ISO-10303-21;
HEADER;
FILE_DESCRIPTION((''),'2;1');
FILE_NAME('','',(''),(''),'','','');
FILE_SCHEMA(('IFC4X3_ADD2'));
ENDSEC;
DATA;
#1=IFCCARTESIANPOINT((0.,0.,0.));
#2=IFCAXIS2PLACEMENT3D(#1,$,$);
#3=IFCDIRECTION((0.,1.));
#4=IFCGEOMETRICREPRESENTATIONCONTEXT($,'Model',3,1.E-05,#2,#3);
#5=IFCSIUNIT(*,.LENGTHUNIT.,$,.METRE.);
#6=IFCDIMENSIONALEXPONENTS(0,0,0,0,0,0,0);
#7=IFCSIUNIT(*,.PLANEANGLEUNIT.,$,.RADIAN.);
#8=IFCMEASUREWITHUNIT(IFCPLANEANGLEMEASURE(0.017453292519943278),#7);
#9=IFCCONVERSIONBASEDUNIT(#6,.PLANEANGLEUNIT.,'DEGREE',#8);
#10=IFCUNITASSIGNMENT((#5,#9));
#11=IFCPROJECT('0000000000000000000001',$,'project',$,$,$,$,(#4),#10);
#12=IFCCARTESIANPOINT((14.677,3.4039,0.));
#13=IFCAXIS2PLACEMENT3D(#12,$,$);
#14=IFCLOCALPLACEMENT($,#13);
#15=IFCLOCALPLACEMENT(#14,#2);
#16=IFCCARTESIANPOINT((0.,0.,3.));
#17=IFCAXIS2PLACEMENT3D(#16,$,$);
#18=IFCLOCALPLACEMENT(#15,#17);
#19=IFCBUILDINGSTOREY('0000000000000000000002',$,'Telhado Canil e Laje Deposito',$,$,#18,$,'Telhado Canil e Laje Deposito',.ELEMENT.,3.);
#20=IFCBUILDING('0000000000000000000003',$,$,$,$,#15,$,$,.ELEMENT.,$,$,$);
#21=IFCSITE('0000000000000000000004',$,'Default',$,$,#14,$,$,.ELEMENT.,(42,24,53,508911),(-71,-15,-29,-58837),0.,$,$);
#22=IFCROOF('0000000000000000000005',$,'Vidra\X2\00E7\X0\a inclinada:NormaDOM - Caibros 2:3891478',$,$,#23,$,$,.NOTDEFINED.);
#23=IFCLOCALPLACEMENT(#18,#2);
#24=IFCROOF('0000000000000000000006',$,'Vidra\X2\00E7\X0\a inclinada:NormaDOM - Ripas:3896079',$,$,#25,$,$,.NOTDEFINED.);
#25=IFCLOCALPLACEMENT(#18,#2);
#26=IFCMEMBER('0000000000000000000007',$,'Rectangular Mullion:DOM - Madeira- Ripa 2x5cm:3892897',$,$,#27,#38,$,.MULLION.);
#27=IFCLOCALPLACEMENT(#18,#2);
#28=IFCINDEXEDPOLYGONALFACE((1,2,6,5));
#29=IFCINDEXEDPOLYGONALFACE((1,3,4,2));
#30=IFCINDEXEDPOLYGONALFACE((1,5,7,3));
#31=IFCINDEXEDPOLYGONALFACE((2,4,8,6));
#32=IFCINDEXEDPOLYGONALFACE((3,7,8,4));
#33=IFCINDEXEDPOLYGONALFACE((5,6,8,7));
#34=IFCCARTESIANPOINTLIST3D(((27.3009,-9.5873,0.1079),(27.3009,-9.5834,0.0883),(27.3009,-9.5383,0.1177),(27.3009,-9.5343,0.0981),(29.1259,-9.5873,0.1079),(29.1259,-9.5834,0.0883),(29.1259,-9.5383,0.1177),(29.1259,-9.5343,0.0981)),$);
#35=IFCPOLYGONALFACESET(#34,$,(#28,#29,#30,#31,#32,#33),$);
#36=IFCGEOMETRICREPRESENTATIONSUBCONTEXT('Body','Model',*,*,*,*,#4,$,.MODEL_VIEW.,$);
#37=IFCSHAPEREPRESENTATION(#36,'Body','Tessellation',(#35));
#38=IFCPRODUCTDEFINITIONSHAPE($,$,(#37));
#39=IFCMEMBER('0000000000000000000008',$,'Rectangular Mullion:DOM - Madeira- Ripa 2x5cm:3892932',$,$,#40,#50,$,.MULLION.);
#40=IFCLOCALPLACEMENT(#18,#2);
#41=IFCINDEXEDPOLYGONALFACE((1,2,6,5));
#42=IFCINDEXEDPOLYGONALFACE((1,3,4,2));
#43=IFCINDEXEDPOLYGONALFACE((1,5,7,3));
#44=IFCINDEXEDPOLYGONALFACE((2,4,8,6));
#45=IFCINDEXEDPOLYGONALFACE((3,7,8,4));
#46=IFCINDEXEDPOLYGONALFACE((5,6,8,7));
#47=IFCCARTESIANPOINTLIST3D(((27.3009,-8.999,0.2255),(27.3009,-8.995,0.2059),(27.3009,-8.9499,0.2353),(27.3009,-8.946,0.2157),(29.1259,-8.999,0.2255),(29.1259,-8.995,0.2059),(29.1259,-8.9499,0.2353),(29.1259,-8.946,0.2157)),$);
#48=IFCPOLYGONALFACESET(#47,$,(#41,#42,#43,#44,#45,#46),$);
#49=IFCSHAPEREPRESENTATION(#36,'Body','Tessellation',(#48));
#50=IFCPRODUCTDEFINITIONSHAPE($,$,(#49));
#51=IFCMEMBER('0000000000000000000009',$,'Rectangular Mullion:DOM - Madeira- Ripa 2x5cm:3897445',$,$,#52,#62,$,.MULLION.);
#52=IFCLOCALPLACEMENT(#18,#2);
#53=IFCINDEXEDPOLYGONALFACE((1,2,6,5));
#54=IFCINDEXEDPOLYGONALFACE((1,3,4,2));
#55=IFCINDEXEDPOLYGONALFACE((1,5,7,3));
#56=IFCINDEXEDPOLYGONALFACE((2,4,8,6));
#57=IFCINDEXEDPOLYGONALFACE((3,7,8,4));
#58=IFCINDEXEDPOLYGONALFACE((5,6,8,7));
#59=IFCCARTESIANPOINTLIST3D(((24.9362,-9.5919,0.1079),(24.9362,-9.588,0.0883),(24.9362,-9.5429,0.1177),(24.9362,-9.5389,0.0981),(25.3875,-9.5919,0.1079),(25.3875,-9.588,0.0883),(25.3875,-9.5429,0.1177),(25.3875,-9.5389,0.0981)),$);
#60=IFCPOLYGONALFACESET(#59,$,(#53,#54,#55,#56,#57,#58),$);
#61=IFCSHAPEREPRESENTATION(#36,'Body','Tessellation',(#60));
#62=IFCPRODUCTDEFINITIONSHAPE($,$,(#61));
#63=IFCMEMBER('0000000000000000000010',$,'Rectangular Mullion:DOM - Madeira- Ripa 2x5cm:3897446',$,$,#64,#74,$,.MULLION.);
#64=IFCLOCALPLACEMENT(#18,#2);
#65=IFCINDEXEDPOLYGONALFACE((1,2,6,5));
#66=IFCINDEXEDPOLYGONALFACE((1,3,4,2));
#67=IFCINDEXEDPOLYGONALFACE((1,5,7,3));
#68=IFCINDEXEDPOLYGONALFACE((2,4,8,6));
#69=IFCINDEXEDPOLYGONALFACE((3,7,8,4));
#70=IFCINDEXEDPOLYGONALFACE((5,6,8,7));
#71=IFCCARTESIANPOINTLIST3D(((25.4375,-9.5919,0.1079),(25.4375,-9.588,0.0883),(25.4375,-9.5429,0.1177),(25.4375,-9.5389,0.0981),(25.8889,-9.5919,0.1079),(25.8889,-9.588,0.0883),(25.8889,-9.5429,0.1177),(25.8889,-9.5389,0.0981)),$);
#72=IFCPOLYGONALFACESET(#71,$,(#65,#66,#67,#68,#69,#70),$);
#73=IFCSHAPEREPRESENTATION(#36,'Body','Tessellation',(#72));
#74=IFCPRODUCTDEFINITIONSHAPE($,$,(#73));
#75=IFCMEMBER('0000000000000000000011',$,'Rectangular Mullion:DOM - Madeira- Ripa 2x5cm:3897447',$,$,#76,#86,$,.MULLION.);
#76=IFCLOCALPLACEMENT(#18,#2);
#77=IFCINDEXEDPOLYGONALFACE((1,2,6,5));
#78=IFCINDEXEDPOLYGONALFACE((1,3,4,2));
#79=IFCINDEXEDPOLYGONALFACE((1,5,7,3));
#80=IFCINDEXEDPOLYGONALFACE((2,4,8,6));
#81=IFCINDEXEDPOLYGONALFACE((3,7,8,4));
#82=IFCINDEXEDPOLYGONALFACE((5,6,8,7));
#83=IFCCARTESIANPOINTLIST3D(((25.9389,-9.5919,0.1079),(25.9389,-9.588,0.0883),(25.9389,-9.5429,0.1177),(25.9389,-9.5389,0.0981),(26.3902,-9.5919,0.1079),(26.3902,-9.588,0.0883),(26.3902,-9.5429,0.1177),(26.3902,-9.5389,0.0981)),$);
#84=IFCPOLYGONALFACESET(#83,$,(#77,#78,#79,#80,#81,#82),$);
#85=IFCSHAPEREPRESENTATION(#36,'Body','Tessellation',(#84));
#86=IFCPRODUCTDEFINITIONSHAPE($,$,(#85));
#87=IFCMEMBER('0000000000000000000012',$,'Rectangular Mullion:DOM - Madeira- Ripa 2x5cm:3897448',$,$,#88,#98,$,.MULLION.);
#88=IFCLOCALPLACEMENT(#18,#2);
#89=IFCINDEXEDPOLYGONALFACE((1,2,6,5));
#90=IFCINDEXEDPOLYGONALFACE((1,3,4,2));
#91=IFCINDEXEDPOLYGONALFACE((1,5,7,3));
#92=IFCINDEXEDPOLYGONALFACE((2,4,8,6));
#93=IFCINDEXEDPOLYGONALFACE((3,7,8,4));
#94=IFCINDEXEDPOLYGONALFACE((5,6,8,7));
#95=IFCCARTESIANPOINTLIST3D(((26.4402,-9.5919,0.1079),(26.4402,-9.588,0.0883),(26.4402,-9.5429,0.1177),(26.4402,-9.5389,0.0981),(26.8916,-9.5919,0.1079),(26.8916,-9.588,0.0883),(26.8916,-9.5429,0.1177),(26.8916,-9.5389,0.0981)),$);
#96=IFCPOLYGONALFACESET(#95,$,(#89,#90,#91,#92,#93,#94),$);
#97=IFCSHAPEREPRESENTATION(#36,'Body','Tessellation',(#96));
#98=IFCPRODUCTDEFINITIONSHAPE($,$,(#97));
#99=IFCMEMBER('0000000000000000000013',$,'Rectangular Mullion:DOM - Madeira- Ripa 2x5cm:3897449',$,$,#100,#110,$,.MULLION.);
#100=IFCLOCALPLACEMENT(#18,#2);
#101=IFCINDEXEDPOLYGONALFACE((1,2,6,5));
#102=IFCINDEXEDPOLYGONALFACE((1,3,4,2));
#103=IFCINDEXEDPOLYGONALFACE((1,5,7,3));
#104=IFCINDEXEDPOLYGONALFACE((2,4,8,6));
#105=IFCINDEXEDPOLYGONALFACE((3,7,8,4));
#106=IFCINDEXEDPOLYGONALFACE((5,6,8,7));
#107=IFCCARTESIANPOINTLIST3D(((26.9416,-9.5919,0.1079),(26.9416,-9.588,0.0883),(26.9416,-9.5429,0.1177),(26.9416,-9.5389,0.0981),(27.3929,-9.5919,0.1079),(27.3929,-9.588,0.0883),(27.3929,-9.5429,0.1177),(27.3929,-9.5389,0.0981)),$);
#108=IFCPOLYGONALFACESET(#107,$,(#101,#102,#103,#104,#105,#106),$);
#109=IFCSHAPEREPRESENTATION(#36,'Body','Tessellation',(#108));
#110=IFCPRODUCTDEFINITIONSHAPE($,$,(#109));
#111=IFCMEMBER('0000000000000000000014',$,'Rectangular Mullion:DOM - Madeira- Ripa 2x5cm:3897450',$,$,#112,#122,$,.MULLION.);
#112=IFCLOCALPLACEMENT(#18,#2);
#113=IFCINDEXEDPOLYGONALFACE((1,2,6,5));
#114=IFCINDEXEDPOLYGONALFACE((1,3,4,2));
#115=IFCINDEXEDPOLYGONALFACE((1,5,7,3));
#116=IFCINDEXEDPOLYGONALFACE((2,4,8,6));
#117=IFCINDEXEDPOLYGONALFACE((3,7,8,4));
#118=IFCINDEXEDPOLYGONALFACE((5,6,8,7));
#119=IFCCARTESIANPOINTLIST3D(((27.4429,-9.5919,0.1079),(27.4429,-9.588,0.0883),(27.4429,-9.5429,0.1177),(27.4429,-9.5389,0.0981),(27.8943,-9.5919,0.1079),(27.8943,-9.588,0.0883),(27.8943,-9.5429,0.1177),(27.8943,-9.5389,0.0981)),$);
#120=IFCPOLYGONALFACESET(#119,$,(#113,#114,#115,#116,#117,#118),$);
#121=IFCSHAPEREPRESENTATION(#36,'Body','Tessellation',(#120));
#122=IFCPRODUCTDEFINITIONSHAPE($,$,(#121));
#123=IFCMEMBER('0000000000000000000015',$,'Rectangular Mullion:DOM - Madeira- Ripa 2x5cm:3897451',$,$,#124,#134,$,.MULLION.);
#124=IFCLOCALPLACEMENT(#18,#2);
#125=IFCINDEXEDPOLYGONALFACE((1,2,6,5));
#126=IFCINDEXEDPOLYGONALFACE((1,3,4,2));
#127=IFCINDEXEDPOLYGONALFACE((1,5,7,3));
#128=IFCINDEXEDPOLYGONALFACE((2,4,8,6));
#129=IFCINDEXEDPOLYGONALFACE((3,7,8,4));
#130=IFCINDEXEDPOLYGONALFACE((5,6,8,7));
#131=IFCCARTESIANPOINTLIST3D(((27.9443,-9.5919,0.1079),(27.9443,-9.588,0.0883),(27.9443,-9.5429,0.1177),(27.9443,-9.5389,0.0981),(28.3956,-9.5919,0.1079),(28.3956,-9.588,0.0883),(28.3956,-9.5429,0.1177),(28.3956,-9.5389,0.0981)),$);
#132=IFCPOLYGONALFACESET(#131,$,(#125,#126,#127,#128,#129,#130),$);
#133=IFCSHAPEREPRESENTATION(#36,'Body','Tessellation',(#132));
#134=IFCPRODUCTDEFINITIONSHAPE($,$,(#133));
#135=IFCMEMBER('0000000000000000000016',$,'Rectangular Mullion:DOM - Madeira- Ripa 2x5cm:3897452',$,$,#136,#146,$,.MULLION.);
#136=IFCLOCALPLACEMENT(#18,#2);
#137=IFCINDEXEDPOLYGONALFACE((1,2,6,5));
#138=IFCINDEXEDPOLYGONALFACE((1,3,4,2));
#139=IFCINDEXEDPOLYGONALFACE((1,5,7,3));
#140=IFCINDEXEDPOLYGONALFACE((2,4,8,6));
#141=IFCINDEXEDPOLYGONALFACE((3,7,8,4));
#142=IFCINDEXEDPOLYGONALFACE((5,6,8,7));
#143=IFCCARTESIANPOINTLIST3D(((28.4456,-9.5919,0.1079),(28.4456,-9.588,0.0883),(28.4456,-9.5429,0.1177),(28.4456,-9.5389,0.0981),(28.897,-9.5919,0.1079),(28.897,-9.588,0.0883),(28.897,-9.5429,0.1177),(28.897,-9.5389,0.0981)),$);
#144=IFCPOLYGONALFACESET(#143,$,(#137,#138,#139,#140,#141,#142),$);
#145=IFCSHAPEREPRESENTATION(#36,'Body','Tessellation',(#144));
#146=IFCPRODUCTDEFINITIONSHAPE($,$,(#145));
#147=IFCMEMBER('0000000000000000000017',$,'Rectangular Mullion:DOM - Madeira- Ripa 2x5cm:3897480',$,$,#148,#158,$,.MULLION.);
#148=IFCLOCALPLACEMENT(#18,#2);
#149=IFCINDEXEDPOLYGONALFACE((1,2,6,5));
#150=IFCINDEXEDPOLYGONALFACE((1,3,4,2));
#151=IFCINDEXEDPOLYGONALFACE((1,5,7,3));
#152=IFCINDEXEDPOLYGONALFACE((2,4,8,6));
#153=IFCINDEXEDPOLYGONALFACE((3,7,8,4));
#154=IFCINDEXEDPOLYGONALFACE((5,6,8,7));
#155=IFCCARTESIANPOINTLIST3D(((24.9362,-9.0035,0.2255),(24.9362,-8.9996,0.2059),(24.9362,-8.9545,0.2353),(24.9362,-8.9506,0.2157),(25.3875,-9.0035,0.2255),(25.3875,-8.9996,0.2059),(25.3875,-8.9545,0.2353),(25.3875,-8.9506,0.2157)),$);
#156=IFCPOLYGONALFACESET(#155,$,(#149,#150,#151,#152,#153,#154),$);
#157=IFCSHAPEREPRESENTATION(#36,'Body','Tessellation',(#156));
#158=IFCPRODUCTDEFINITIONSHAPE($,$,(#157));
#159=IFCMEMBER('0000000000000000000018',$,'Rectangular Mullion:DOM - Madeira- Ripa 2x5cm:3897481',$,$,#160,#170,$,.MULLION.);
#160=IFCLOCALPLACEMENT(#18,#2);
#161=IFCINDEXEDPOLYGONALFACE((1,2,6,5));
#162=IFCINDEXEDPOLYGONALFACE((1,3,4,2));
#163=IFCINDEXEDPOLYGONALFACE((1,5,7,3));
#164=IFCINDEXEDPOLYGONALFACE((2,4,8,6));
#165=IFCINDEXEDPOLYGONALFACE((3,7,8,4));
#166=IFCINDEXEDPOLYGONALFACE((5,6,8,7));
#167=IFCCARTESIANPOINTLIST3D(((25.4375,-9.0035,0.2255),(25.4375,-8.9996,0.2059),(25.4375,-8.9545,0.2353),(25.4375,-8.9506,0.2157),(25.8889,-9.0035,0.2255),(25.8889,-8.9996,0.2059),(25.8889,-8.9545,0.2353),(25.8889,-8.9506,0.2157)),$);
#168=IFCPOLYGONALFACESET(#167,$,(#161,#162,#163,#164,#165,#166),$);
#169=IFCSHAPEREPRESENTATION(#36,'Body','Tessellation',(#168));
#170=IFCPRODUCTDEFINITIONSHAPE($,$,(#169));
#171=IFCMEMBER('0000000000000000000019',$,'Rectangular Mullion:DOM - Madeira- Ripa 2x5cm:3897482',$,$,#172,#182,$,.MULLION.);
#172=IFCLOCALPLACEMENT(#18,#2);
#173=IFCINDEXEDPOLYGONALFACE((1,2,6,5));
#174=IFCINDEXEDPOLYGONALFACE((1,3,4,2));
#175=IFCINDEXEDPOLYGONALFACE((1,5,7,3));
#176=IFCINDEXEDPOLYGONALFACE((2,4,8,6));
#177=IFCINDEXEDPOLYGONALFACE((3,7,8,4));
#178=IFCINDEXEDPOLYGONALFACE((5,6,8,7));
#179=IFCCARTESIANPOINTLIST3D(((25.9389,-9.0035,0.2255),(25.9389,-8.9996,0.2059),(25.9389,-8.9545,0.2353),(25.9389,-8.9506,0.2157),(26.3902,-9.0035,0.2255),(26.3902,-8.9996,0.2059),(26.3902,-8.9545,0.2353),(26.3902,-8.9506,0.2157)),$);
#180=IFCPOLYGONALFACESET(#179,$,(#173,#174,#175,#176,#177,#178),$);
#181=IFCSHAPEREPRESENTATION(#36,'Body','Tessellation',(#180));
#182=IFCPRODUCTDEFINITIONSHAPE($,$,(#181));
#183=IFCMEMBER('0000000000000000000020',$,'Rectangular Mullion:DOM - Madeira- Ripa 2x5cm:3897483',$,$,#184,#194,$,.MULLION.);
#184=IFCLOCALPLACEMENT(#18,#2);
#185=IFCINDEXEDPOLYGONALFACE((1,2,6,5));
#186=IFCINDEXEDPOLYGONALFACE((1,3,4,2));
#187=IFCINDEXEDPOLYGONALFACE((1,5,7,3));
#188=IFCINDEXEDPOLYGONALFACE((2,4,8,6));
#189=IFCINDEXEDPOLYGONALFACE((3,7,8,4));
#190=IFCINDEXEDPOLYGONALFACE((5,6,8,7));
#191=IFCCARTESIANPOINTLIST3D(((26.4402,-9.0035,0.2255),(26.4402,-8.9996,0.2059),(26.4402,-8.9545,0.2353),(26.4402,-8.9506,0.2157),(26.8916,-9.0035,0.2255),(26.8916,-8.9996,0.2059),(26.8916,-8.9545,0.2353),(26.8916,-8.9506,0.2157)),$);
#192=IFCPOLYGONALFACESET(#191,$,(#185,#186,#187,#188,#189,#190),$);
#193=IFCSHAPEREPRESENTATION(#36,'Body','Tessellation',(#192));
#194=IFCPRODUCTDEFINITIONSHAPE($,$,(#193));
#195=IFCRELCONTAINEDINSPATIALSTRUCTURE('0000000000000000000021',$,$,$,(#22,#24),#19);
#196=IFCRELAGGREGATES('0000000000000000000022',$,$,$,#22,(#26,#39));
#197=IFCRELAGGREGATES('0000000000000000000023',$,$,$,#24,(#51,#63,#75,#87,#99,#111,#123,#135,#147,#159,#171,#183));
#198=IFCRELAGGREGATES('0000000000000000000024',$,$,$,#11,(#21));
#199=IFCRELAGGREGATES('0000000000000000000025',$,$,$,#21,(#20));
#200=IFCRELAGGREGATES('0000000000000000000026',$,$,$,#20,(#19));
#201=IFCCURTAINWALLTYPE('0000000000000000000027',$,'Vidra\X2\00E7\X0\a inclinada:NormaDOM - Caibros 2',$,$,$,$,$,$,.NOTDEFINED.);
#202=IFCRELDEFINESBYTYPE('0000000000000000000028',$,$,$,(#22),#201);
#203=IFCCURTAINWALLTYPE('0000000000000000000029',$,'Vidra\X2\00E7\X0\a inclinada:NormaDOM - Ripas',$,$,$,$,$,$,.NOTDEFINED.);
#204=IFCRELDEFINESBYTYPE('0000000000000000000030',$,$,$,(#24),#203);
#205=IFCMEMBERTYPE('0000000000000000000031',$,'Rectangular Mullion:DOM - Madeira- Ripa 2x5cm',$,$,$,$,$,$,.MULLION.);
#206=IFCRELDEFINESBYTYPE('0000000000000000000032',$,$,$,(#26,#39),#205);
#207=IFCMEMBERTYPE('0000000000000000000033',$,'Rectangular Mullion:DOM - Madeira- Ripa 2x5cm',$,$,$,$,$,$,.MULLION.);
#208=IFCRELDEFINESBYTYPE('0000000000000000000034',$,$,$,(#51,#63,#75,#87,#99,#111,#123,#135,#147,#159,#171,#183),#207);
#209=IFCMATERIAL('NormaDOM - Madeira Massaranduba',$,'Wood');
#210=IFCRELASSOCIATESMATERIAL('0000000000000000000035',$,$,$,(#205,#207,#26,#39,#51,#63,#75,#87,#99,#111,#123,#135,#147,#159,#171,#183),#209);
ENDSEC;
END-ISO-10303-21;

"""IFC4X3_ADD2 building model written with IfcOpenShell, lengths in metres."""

from ifc_helpers import new_model, entity, si_unit, converted_unit, direction, frame, origin, origin_2d_with_axis, place, context, subcontext, project, spatial, rectangle, extrude, source, transform, mapped, material, material_profile, profile_set, profile_usage, type_object, type_shapes, element, aggregate, save


model = new_model("IFC4X3_ADD2")

# Units and contexts
model_context = context("Model", 3, precision=1e-05, world=origin(), true_north=direction((0.0, 1.0)))
body_context = subcontext(model_context, "Body", "Model", "MODEL_VIEW")
ifc_project = project(units=[si_unit("LENGTHUNIT", "METRE"), converted_unit("PLANEANGLEUNIT", "DEGREE", entity("IfcPlaneAngleMeasure", 0.017453292519943278), si_unit("PLANEANGLEUNIT", "RADIAN"), dimensions=[0, 0, 0, 0, 0, 0, 0])], contexts=[model_context])

# Site, building, storey
site_placement = place(None, frame((14.677, 3.4039, 0.0)))
site = spatial("IfcSite", under=ifc_project, at=site_placement, Name="Default", CompositionType="ELEMENT", RefLatitude=(42, 24, 53, 508911), RefLongitude=(-71, -15, -29, -58837), RefElevation=0.0)
building_placement = place(site_placement, origin())
building = spatial("IfcBuilding", under=site, at=building_placement, CompositionType="ELEMENT")
storey_placement = place(building_placement, frame((0.0, 0.0, 3.0)))
storey = spatial("IfcBuildingStorey", under=building, at=storey_placement, Name="Telhado Canil e Laje Deposito", LongName="Telhado Canil e Laje Deposito", CompositionType="ELEMENT", Elevation=3.0)

# Roof
curtain_wall_type_1 = type_object("IfcCurtainWallType", Name="Vidraça inclinada:NormaDOM - Caibros 2", PredefinedType="NOTDEFINED")
roof_1_placement = place(storey_placement, frame((0.0, 0.0, -3.0)))
roof_1 = element("IfcRoof", 1, at=roof_1_placement, inside=storey, type_object=curtain_wall_type_1, Name="Vidraça inclinada:NormaDOM - Caibros 2:3891478", PredefinedType="NOTDEFINED")
ifc_material = material(Name="NormaDOM - Madeira Massaranduba", Category="Wood")

# Roof
curtain_wall_type_2 = type_object("IfcCurtainWallType", Name="Vidraça inclinada:NormaDOM - Ripas", PredefinedType="NOTDEFINED")
roof_2_placement = place(storey_placement, frame((0.0, 0.0, -3.0)))
roof_2 = element("IfcRoof", 2, at=roof_2_placement, inside=storey, type_object=curtain_wall_type_2, Name="Vidraça inclinada:NormaDOM - Ripas:3896079", PredefinedType="NOTDEFINED")

# Members
ifc_material_profile_1 = material_profile(ifc_material, rectangle(XDim=0.05, YDim=0.02, at=origin_2d_with_axis()), Name="DOM - Madeira- Ripa 2x5cm")
ifc_profile_set_1 = profile_set([ifc_material_profile_1], Name="DOM - Madeira- Ripa 2x5cm")
ifc_profile_usage_1 = profile_usage(ifc_profile_set_1)
member_type_1 = type_object("IfcMemberType", Name="Rectangular Mullion:DOM - Madeira- Ripa 2x5cm", PredefinedType="MULLION", material=ifc_profile_set_1)
shared_shape_1 = source(origin(), body_context, "Body", "SweptSolid", [
    extrude(rectangle(XDim=0.05, YDim=0.02, at=origin_2d_with_axis()), frame((0.025, 0.01, -1.825), z_axis=(0.0, 0.0, 1.0), x_axis=(-1.0, 0.0, 0.0)), (0.0, 0.0, 1.0), 1.825),
])
type_shapes(member_type_1, [shared_shape_1])
member_1_placement = place(roof_1_placement, frame((27.3009, -9.5873, 3.1079), z_axis=(-1.0, 0.0, 0.0), x_axis=(0.0, 0.980581, 0.196116)))
member_1 = element("IfcMember", 3, at=member_1_placement, type_object=member_type_1, material=ifc_profile_usage_1, Name="Rectangular Mullion:DOM - Madeira- Ripa 2x5cm:3892897", PredefinedType="MULLION", context=body_context, shape_type="MappedRepresentation", body=[
    mapped(shared_shape_1, transform((0.0, 0.0, 0.0), scale=1.0)),
])
member_2_placement = place(roof_1_placement, frame((27.3009, -8.999, 3.2255), z_axis=(-1.0, 0.0, 0.0), x_axis=(0.0, 0.980581, 0.196116)))
member_2 = element("IfcMember", 4, at=member_2_placement, type_object=member_type_1, material=ifc_profile_usage_1, Name="Rectangular Mullion:DOM - Madeira- Ripa 2x5cm:3892932", PredefinedType="MULLION", context=body_context, shape_type="MappedRepresentation", body=[
    mapped(shared_shape_1, transform((0.0, 0.0, 0.0), scale=1.0)),
])
aggregate(roof_1, [member_1, member_2])
member_type_2 = type_object("IfcMemberType", Name="Rectangular Mullion:DOM - Madeira- Ripa 2x5cm", PredefinedType="MULLION", material=ifc_profile_set_1)
shared_shape_2 = source(origin(), body_context, "Body", "SweptSolid", [
    extrude(rectangle(XDim=0.05, YDim=0.02, at=origin_2d_with_axis()), frame((0.025, 0.01, -0.4514), z_axis=(0.0, 0.0, 1.0), x_axis=(-1.0, 0.0, 0.0)), (0.0, 0.0, 1.0), 0.4514),
])
type_shapes(member_type_2, [shared_shape_2])
member_3_placement = place(roof_2_placement, frame((24.9362, -9.5919, 3.1079), z_axis=(-1.0, 0.0, 0.0), x_axis=(0.0, 0.980581, 0.196116)))
member_3 = element("IfcMember", 5, at=member_3_placement, type_object=member_type_2, material=ifc_profile_usage_1, Name="Rectangular Mullion:DOM - Madeira- Ripa 2x5cm:3897445", PredefinedType="MULLION", context=body_context, shape_type="MappedRepresentation", body=[
    mapped(shared_shape_2, transform((0.0, 0.0, 0.0), scale=1.0)),
])
member_4_placement = place(roof_2_placement, frame((25.4375, -9.5919, 3.1079), z_axis=(-1.0, 0.0, 0.0), x_axis=(0.0, 0.980581, 0.196116)))
member_4 = element("IfcMember", 6, at=member_4_placement, type_object=member_type_2, material=ifc_profile_usage_1, Name="Rectangular Mullion:DOM - Madeira- Ripa 2x5cm:3897446", PredefinedType="MULLION", context=body_context, shape_type="MappedRepresentation", body=[
    mapped(shared_shape_2, transform((0.0, 0.0, 0.0), scale=1.0)),
])
member_5_placement = place(roof_2_placement, frame((25.9389, -9.5919, 3.1079), z_axis=(-1.0, 0.0, 0.0), x_axis=(0.0, 0.980581, 0.196116)))
member_5 = element("IfcMember", 7, at=member_5_placement, type_object=member_type_2, material=ifc_profile_usage_1, Name="Rectangular Mullion:DOM - Madeira- Ripa 2x5cm:3897447", PredefinedType="MULLION", context=body_context, shape_type="MappedRepresentation", body=[
    mapped(shared_shape_2, transform((0.0, 0.0, 0.0), scale=1.0)),
])
member_6_placement = place(roof_2_placement, frame((26.4402, -9.5919, 3.1079), z_axis=(-1.0, 0.0, 0.0), x_axis=(0.0, 0.980581, 0.196116)))
member_6 = element("IfcMember", 8, at=member_6_placement, type_object=member_type_2, material=ifc_profile_usage_1, Name="Rectangular Mullion:DOM - Madeira- Ripa 2x5cm:3897448", PredefinedType="MULLION", context=body_context, shape_type="MappedRepresentation", body=[
    mapped(shared_shape_2, transform((0.0, 0.0, 0.0), scale=1.0)),
])
member_7_placement = place(roof_2_placement, frame((26.9416, -9.5919, 3.1079), z_axis=(-1.0, 0.0, 0.0), x_axis=(0.0, 0.980581, 0.196116)))
member_7 = element("IfcMember", 9, at=member_7_placement, type_object=member_type_2, material=ifc_profile_usage_1, Name="Rectangular Mullion:DOM - Madeira- Ripa 2x5cm:3897449", PredefinedType="MULLION", context=body_context, shape_type="MappedRepresentation", body=[
    mapped(shared_shape_2, transform((0.0, 0.0, 0.0), scale=1.0)),
])
member_8_placement = place(roof_2_placement, frame((27.4429, -9.5919, 3.1079), z_axis=(-1.0, 0.0, 0.0), x_axis=(0.0, 0.980581, 0.196116)))
member_8 = element("IfcMember", 10, at=member_8_placement, type_object=member_type_2, material=ifc_profile_usage_1, Name="Rectangular Mullion:DOM - Madeira- Ripa 2x5cm:3897450", PredefinedType="MULLION", context=body_context, shape_type="MappedRepresentation", body=[
    mapped(shared_shape_2, transform((0.0, 0.0, 0.0), scale=1.0)),
])
member_9_placement = place(roof_2_placement, frame((27.9443, -9.5919, 3.1079), z_axis=(-1.0, 0.0, 0.0), x_axis=(0.0, 0.980581, 0.196116)))
member_9 = element("IfcMember", 11, at=member_9_placement, type_object=member_type_2, material=ifc_profile_usage_1, Name="Rectangular Mullion:DOM - Madeira- Ripa 2x5cm:3897451", PredefinedType="MULLION", context=body_context, shape_type="MappedRepresentation", body=[
    mapped(shared_shape_2, transform((0.0, 0.0, 0.0), scale=1.0)),
])
member_10_placement = place(roof_2_placement, frame((28.4456, -9.5919, 3.1079), z_axis=(-1.0, 0.0, 0.0), x_axis=(0.0, 0.980581, 0.196116)))
member_10 = element("IfcMember", 12, at=member_10_placement, type_object=member_type_2, material=ifc_profile_usage_1, Name="Rectangular Mullion:DOM - Madeira- Ripa 2x5cm:3897452", PredefinedType="MULLION", context=body_context, shape_type="MappedRepresentation", body=[
    mapped(shared_shape_2, transform((0.0, 0.0, 0.0), scale=1.0)),
])
member_11_placement = place(roof_2_placement, frame((24.9362, -9.0035, 3.2255), z_axis=(-1.0, 0.0, 0.0), x_axis=(0.0, 0.980581, 0.196116)))
member_11 = element("IfcMember", 13, at=member_11_placement, type_object=member_type_2, material=ifc_profile_usage_1, Name="Rectangular Mullion:DOM - Madeira- Ripa 2x5cm:3897480", PredefinedType="MULLION", context=body_context, shape_type="MappedRepresentation", body=[
    mapped(shared_shape_2, transform((0.0, 0.0, 0.0), scale=1.0)),
])
member_12_placement = place(roof_2_placement, frame((25.4375, -9.0035, 3.2255), z_axis=(-1.0, 0.0, 0.0), x_axis=(0.0, 0.980581, 0.196116)))
member_12 = element("IfcMember", 14, at=member_12_placement, type_object=member_type_2, material=ifc_profile_usage_1, Name="Rectangular Mullion:DOM - Madeira- Ripa 2x5cm:3897481", PredefinedType="MULLION", context=body_context, shape_type="MappedRepresentation", body=[
    mapped(shared_shape_2, transform((0.0, 0.0, 0.0), scale=1.0)),
])
member_13_placement = place(roof_2_placement, frame((25.9389, -9.0035, 3.2255), z_axis=(-1.0, 0.0, 0.0), x_axis=(0.0, 0.980581, 0.196116)))
member_13 = element("IfcMember", 15, at=member_13_placement, type_object=member_type_2, material=ifc_profile_usage_1, Name="Rectangular Mullion:DOM - Madeira- Ripa 2x5cm:3897482", PredefinedType="MULLION", context=body_context, shape_type="MappedRepresentation", body=[
    mapped(shared_shape_2, transform((0.0, 0.0, 0.0), scale=1.0)),
])
member_14_placement = place(roof_2_placement, frame((26.4402, -9.0035, 3.2255), z_axis=(-1.0, 0.0, 0.0), x_axis=(0.0, 0.980581, 0.196116)))
member_14 = element("IfcMember", 16, at=member_14_placement, type_object=member_type_2, material=ifc_profile_usage_1, Name="Rectangular Mullion:DOM - Madeira- Ripa 2x5cm:3897483", PredefinedType="MULLION", context=body_context, shape_type="MappedRepresentation", body=[
    mapped(shared_shape_2, transform((0.0, 0.0, 0.0), scale=1.0)),
])
aggregate(roof_2, [member_3, member_4, member_5, member_6, member_7, member_8, member_9, member_10, member_11, member_12, member_13, member_14])

save(model, "model.ifc")
